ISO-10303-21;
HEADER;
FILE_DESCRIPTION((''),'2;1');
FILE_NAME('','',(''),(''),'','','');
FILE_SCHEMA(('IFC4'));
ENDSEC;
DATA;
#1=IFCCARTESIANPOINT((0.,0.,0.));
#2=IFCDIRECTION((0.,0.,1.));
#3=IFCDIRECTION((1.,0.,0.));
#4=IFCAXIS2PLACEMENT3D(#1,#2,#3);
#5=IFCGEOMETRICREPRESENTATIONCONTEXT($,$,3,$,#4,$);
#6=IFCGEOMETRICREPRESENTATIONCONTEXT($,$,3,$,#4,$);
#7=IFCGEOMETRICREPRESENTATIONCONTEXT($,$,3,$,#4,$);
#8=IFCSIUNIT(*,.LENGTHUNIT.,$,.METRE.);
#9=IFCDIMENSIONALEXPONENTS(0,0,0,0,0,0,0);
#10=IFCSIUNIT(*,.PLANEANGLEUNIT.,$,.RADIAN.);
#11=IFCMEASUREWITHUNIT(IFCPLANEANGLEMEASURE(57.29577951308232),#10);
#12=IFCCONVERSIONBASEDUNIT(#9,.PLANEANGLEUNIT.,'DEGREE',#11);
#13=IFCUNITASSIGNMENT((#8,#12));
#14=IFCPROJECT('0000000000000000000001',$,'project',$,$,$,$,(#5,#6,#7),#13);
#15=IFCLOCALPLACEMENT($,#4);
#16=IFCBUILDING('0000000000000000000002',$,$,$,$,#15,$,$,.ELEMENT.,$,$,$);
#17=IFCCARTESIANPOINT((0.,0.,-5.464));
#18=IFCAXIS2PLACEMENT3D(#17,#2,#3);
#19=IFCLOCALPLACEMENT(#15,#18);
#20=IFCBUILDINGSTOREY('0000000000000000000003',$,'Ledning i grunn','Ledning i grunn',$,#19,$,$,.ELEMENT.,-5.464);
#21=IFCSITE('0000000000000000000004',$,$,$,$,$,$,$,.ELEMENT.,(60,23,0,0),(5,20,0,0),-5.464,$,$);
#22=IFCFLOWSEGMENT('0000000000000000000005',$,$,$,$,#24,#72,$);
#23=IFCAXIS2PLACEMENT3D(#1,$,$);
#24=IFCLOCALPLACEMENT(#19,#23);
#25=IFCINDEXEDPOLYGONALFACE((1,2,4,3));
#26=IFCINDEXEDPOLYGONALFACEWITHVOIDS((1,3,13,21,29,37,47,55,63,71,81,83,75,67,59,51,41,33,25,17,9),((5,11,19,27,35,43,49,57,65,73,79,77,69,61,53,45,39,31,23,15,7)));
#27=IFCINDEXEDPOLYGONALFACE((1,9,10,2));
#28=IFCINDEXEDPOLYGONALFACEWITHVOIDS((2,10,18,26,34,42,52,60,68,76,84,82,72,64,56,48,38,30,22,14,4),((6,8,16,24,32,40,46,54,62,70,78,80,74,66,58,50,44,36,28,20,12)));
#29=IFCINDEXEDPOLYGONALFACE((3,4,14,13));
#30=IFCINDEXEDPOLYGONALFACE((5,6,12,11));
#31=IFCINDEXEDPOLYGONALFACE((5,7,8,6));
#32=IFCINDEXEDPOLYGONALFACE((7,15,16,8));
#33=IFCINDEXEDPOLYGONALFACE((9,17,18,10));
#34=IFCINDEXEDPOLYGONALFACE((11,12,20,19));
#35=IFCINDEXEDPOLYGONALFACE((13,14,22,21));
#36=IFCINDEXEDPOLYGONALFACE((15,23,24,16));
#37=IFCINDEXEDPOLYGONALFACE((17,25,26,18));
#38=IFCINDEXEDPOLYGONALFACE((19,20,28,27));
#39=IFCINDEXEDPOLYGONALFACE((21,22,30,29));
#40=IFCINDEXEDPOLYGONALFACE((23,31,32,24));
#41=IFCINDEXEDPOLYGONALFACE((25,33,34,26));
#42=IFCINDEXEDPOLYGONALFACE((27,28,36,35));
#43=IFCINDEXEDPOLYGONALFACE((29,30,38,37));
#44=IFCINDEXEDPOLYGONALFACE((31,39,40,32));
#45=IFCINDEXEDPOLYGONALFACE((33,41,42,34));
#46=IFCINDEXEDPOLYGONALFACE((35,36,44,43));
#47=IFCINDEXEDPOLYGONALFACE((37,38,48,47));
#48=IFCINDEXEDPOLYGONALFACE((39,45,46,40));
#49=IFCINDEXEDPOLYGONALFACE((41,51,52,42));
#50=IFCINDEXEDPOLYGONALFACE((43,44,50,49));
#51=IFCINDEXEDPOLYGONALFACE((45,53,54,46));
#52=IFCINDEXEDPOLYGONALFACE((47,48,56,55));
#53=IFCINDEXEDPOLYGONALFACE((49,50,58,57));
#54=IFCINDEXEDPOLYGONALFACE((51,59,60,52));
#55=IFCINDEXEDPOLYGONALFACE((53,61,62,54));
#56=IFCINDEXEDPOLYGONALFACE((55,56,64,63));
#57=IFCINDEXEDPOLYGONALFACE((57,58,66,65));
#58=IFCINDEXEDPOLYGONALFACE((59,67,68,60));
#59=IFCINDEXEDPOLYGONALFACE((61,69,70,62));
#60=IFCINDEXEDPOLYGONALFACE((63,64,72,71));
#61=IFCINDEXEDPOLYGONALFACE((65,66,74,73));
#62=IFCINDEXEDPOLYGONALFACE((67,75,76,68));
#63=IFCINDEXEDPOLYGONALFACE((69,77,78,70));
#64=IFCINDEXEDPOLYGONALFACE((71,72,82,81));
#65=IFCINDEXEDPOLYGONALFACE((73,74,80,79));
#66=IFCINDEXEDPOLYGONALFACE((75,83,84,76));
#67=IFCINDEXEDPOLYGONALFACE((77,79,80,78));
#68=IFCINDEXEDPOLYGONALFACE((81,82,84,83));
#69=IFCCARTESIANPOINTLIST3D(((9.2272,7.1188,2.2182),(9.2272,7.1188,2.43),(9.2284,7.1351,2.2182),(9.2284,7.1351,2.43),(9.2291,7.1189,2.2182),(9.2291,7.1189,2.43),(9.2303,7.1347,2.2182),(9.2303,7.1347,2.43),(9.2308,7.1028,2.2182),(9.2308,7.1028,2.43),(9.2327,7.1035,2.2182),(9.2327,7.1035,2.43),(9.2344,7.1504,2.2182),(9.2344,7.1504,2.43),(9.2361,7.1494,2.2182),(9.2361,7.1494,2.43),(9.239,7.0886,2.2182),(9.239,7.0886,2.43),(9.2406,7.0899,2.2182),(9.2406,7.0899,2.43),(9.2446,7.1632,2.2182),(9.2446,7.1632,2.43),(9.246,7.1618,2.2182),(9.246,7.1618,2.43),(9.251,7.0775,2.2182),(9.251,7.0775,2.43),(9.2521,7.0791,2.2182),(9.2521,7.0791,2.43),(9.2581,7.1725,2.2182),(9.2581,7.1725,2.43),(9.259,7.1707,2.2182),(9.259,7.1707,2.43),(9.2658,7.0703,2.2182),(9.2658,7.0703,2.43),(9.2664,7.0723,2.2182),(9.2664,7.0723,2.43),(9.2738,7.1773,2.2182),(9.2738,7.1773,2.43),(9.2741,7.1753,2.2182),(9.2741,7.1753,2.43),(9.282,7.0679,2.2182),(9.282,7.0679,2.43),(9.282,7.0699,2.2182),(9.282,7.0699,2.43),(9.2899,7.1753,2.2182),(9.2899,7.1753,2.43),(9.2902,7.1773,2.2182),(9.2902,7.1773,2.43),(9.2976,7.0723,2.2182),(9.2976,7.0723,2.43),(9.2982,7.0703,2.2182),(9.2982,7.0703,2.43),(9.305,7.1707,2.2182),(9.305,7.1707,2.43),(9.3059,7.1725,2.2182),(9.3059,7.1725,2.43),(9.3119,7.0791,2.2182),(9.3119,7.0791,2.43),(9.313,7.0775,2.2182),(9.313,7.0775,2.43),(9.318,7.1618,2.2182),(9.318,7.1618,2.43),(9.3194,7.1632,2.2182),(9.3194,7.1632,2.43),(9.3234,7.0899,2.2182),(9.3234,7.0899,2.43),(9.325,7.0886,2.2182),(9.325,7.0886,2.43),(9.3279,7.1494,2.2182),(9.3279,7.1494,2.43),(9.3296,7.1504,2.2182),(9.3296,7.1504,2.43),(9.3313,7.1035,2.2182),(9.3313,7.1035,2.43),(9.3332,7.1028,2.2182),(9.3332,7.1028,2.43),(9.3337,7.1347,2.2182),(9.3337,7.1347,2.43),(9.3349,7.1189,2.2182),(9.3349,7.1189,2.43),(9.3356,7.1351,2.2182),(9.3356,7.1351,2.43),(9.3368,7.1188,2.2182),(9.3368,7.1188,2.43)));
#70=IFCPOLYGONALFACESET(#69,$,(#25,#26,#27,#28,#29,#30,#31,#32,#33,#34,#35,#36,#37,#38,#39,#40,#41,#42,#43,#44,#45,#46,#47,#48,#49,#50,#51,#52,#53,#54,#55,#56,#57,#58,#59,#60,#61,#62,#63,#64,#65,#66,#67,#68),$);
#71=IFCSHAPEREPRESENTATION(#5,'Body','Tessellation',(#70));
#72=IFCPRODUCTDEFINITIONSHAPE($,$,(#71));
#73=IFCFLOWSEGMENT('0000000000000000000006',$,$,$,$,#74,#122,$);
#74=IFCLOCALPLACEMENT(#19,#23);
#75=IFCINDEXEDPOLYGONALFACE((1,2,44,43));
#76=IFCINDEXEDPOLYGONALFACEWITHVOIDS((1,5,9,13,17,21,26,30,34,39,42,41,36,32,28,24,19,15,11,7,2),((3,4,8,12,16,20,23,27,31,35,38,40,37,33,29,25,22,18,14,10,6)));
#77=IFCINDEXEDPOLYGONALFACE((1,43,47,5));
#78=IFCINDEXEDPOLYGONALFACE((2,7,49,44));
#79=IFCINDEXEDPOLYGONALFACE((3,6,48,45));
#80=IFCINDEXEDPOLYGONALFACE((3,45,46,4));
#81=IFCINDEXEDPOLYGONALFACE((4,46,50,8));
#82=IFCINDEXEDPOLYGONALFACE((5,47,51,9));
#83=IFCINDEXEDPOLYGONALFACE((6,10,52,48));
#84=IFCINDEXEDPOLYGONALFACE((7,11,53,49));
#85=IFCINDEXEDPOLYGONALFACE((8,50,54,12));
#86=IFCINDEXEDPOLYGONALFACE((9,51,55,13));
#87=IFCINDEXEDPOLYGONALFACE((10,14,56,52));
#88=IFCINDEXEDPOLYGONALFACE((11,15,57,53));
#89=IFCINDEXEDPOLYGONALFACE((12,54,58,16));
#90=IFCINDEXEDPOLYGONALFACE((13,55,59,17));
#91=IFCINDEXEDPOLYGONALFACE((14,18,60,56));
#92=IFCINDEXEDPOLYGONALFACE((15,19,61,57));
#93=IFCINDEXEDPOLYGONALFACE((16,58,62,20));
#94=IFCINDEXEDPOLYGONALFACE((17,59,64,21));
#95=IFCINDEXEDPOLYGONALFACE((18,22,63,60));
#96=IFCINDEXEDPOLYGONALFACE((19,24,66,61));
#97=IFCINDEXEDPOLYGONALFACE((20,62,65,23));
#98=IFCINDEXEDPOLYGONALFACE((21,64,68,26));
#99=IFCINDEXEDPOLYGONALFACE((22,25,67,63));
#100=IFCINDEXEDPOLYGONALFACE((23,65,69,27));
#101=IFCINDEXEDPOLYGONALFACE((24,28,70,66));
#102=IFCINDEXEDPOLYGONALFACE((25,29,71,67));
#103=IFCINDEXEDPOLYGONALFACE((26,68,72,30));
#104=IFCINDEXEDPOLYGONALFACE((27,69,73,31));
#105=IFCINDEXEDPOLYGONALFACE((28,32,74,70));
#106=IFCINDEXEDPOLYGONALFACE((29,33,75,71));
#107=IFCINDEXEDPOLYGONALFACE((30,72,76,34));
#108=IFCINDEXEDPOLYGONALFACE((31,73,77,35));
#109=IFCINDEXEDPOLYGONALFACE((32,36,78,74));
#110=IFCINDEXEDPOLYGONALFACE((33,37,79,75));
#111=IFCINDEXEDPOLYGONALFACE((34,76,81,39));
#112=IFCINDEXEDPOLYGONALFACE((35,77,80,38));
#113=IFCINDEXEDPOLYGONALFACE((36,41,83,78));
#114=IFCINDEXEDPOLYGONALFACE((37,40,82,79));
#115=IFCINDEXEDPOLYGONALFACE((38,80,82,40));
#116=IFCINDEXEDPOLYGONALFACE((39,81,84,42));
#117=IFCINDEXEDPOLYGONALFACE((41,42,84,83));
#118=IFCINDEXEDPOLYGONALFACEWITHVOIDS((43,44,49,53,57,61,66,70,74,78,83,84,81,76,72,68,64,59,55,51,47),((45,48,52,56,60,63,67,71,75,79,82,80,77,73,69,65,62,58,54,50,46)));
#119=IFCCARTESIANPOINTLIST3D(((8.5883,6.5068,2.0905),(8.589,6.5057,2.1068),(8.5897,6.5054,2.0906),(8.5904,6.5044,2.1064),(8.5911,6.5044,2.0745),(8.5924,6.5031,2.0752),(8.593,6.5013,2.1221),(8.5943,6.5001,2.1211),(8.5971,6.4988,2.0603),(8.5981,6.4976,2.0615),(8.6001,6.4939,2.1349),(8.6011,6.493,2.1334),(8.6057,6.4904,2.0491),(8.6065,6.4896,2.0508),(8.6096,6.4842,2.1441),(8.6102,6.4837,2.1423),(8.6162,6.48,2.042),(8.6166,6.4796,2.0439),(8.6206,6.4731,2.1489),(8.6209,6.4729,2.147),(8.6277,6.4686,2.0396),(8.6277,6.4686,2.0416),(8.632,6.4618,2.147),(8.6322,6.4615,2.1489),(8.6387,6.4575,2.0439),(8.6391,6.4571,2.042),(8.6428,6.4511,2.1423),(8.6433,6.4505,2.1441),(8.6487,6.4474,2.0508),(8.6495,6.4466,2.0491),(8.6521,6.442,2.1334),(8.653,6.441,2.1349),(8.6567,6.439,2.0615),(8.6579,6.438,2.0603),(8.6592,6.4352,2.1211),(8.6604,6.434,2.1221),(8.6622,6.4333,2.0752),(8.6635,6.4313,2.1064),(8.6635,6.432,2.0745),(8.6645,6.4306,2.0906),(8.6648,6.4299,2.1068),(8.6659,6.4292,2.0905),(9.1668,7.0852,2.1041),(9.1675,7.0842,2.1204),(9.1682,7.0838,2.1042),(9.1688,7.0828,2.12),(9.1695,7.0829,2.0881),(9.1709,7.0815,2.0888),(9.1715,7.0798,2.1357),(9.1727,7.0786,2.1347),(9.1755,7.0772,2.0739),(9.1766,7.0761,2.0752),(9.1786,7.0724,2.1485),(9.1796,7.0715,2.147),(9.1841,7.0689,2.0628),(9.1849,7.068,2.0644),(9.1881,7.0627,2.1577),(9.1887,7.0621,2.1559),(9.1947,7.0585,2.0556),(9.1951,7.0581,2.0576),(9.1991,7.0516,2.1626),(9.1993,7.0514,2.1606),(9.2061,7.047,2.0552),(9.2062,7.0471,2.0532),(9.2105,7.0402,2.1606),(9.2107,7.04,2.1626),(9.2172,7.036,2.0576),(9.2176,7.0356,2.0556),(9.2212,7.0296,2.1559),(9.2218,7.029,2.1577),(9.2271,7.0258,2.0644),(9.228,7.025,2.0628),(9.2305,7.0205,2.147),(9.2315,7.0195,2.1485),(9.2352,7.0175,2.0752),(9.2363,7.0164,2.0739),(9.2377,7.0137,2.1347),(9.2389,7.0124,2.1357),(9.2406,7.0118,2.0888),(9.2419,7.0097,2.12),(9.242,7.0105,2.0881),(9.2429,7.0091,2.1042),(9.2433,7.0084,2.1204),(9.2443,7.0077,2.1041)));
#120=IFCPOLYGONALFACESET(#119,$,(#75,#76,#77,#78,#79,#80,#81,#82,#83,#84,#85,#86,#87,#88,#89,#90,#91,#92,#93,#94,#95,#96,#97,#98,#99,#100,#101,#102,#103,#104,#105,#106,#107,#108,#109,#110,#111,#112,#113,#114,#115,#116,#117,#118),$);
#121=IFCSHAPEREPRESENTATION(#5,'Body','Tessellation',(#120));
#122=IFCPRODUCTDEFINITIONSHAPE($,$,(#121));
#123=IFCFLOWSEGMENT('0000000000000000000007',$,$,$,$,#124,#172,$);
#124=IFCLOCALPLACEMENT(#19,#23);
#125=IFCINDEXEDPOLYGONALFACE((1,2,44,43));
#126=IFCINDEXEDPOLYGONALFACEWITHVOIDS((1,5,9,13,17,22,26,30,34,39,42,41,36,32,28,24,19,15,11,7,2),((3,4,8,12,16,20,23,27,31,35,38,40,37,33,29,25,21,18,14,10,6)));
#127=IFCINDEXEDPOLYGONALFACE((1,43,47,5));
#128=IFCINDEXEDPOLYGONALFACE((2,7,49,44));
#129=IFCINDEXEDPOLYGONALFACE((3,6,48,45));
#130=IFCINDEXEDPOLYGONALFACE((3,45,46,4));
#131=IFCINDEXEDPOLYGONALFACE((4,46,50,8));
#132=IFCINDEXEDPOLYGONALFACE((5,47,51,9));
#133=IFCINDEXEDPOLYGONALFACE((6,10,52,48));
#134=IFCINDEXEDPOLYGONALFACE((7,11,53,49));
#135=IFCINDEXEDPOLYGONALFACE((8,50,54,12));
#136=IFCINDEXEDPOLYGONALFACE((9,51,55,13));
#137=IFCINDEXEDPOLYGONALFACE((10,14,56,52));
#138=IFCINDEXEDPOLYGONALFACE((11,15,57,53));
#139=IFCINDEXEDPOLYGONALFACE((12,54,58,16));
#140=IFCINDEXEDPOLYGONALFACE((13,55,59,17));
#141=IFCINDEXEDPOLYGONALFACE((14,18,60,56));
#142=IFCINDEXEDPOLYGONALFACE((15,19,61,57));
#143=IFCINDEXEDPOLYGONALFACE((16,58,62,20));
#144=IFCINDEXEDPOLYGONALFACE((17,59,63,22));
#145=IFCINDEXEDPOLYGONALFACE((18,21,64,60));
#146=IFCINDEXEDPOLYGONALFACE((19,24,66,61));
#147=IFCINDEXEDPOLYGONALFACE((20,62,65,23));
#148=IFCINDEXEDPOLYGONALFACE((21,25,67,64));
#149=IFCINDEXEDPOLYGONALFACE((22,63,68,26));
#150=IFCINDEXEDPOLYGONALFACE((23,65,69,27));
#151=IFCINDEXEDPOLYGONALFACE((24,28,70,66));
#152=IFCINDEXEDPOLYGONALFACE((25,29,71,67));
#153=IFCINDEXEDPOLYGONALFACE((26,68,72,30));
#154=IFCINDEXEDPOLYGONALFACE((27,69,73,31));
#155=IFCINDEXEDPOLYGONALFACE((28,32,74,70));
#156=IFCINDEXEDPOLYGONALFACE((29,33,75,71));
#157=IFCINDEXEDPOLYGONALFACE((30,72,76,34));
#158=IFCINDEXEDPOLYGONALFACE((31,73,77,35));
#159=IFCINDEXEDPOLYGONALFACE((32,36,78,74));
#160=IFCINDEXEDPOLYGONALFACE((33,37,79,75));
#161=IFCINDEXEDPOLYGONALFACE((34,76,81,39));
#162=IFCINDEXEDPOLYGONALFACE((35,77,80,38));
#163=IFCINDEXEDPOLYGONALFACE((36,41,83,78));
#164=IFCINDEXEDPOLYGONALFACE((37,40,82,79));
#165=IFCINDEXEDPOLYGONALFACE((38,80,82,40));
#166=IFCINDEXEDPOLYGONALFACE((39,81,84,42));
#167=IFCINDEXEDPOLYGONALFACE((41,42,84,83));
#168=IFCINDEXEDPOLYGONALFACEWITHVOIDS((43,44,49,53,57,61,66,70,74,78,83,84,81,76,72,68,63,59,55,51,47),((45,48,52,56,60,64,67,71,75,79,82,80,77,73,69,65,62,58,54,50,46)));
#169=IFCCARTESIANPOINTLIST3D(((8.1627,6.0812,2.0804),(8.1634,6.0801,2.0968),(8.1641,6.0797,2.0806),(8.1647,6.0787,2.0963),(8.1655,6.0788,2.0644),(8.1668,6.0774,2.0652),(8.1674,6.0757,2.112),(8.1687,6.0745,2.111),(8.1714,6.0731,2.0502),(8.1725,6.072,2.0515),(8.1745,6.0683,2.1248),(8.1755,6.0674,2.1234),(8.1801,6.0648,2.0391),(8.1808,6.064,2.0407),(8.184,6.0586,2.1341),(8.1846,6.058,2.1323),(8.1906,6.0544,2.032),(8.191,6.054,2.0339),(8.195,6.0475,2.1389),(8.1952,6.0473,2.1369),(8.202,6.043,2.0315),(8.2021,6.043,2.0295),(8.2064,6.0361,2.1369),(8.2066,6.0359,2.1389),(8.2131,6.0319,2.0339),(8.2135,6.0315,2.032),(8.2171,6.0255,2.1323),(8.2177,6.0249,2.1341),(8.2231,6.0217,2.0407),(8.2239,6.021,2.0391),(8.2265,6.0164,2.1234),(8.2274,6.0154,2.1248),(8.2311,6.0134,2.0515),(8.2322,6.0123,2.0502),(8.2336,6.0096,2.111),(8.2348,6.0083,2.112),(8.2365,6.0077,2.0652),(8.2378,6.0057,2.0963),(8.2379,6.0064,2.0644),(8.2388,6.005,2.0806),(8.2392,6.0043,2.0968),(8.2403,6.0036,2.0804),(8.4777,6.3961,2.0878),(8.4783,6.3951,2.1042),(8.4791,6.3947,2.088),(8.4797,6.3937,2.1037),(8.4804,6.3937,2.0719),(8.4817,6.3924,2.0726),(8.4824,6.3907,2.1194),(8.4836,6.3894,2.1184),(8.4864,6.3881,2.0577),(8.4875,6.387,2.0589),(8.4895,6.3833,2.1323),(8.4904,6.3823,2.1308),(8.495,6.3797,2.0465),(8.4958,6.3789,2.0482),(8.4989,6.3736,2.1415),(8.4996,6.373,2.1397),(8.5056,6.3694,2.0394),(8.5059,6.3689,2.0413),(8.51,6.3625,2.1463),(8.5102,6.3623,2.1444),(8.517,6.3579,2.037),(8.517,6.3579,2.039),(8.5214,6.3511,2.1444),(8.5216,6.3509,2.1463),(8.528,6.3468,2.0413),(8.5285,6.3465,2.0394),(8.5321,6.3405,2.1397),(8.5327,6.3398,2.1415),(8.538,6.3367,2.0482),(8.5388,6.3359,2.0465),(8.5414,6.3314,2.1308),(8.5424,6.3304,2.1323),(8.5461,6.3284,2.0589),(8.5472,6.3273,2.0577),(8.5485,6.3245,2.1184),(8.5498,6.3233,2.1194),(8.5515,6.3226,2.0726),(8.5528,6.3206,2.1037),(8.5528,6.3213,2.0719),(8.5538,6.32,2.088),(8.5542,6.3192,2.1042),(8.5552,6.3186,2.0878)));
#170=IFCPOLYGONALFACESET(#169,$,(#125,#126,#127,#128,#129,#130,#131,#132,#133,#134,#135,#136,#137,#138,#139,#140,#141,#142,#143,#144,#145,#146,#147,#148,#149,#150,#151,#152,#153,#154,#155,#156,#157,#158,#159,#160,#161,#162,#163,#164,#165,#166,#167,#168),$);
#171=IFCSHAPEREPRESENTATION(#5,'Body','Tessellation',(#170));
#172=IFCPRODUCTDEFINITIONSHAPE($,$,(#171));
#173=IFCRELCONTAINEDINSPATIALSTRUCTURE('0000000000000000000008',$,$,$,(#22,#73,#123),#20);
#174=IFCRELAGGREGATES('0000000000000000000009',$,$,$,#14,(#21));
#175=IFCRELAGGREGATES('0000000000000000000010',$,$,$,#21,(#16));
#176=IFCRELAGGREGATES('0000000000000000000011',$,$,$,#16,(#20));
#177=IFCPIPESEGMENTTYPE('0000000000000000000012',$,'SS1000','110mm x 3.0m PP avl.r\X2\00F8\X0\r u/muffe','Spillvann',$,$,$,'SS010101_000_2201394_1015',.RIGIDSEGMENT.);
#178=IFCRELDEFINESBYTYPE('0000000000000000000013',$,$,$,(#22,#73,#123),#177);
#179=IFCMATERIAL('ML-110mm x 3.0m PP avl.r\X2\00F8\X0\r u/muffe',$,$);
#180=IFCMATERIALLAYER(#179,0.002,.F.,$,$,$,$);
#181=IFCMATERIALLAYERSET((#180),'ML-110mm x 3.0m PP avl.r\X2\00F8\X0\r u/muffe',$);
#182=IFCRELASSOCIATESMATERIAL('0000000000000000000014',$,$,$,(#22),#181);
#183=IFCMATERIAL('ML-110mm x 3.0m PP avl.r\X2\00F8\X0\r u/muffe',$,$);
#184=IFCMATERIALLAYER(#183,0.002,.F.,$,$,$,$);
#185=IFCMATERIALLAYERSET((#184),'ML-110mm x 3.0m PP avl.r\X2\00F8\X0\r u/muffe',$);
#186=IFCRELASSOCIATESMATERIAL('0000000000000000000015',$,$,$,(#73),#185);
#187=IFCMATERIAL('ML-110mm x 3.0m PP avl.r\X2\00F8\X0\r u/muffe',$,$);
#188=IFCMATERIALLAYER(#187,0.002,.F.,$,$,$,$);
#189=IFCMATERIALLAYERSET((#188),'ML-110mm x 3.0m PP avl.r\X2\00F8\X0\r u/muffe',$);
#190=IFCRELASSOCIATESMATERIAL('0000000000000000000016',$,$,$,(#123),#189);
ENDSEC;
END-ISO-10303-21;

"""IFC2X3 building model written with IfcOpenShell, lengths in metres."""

from ifc_helpers import new_model, entity, si_unit, converted_unit, frame, origin_with_axes, origin_2d_with_axis, place, context, project, spatial, hollow_circle, extrude, material, layer, layer_set, layer_usage, type_object, element, save


model = new_model("IFC2X3")

# Units and contexts
context_of_model_1 = context(None, 3, world=origin_with_axes())
context_of_model_2 = context(None, 3, world=origin_with_axes())
context_of_model_3 = context(None, 3, world=origin_with_axes())
ifc_project = project(units=[si_unit("LENGTHUNIT", "METRE"), converted_unit("PLANEANGLEUNIT", "DEGREE", entity("IfcPlaneAngleMeasure", 57.29577951308232), si_unit("PLANEANGLEUNIT", "RADIAN"), dimensions=[0, 0, 0, 0, 0, 0, 0])], contexts=[context_of_model_1, context_of_model_2, context_of_model_3])

# Site, building, storey
site = spatial("IfcSite", under=ifc_project, CompositionType="ELEMENT", RefLatitude=(60, 23, 0, 0), RefLongitude=(5, 20, 0, 0), RefElevation=-5.464)
building_placement = place(None, origin_with_axes())
building = spatial("IfcBuilding", under=site, at=building_placement, CompositionType="ELEMENT")
storey_placement = place(building_placement, frame((0.0, 0.0, -5.464), z_axis=(0.0, 0.0, 1.0), x_axis=(1.0, 0.0, 0.0)))
storey = spatial("IfcBuildingStorey", under=building, at=storey_placement, Name="Ledning i grunn", Description="Ledning i grunn", CompositionType="ELEMENT", Elevation=-5.464)

# Flow segments
ifc_material_1 = material(Name="ML-110mm x 3.0m PP avl.rør u/muffe")
ifc_layer_1 = layer(ifc_material_1, 0.002, ventilated=False)
ifc_layer_set_1 = layer_set([ifc_layer_1], Name="ML-110mm x 3.0m PP avl.rør u/muffe")
ifc_layer_usage_1 = layer_usage(ifc_layer_set_1, "AXIS2", "POSITIVE", 0.0)
pipe_segment_type_1 = type_object("IfcPipeSegmentType", Name="SS1000", Description="110mm x 3.0m PP avl.rør u/muffe", ApplicableOccurrence="Spillvann", ElementType="SS010101_000_2201394_1015", PredefinedType="RIGIDSEGMENT")
flow_segment_1_placement = place(storey_placement, frame((9.282, 7.1229, 2.43), z_axis=(0.0, 0.0, -1.0), x_axis=(0.0, -1.0, 0.0)))
element("IfcFlowSegment", 1, at=flow_segment_1_placement, inside=storey, type_object=pipe_segment_type_1, material=ifc_layer_usage_1, context=context_of_model_1, shape_type="SweptSolid", body=[
    extrude(hollow_circle(Radius=0.055, WallThickness=0.002, at=origin_2d_with_axis()), origin_with_axes(), (0.0, 0.0, 1.0), 0.2118),
])
ifc_material_2 = material(Name="ML-110mm x 3.0m PP avl.rør u/muffe")
ifc_layer_2 = layer(ifc_material_2, 0.002, ventilated=False)
ifc_layer_set_2 = layer_set([ifc_layer_2], Name="ML-110mm x 3.0m PP avl.rør u/muffe")
ifc_layer_usage_2 = layer_usage(ifc_layer_set_2, "AXIS2", "POSITIVE", 0.0)
flow_segment_2_placement = place(storey_placement, frame((9.2055, 7.0464, 2.1082), z_axis=(-0.707009, -0.707008, -0.016665), x_axis=(0.011784, 0.011784, -0.999861)))
element("IfcFlowSegment", 2, at=flow_segment_2_placement, inside=storey, type_object=pipe_segment_type_1, material=ifc_layer_usage_2, context=context_of_model_1, shape_type="SweptSolid", body=[
    extrude(hollow_circle(Radius=0.055, WallThickness=0.002, at=origin_2d_with_axis()), origin_with_axes(), (0.0, 0.0, 1.0), 0.8182),
])
ifc_material_3 = material(Name="ML-110mm x 3.0m PP avl.rør u/muffe")
ifc_layer_3 = layer(ifc_material_3, 0.002, ventilated=False)
ifc_layer_set_3 = layer_set([ifc_layer_3], Name="ML-110mm x 3.0m PP avl.rør u/muffe")
ifc_layer_usage_3 = layer_usage(ifc_layer_set_3, "AXIS2", "POSITIVE", 0.0)
flow_segment_3_placement = place(storey_placement, frame((8.5164, 6.3573, 2.092), z_axis=(-0.707009, -0.707008, -0.016665), x_axis=(0.011784, 0.011784, -0.999861)))
element("IfcFlowSegment", 3, at=flow_segment_3_placement, inside=storey, type_object=pipe_segment_type_1, material=ifc_layer_usage_3, context=context_of_model_1, shape_type="SweptSolid", body=[
    extrude(hollow_circle(Radius=0.055, WallThickness=0.002, at=origin_2d_with_axis()), origin_with_axes(), (0.0, 0.0, 1.0), 0.4455),
])

save(model, "model.ifc")
